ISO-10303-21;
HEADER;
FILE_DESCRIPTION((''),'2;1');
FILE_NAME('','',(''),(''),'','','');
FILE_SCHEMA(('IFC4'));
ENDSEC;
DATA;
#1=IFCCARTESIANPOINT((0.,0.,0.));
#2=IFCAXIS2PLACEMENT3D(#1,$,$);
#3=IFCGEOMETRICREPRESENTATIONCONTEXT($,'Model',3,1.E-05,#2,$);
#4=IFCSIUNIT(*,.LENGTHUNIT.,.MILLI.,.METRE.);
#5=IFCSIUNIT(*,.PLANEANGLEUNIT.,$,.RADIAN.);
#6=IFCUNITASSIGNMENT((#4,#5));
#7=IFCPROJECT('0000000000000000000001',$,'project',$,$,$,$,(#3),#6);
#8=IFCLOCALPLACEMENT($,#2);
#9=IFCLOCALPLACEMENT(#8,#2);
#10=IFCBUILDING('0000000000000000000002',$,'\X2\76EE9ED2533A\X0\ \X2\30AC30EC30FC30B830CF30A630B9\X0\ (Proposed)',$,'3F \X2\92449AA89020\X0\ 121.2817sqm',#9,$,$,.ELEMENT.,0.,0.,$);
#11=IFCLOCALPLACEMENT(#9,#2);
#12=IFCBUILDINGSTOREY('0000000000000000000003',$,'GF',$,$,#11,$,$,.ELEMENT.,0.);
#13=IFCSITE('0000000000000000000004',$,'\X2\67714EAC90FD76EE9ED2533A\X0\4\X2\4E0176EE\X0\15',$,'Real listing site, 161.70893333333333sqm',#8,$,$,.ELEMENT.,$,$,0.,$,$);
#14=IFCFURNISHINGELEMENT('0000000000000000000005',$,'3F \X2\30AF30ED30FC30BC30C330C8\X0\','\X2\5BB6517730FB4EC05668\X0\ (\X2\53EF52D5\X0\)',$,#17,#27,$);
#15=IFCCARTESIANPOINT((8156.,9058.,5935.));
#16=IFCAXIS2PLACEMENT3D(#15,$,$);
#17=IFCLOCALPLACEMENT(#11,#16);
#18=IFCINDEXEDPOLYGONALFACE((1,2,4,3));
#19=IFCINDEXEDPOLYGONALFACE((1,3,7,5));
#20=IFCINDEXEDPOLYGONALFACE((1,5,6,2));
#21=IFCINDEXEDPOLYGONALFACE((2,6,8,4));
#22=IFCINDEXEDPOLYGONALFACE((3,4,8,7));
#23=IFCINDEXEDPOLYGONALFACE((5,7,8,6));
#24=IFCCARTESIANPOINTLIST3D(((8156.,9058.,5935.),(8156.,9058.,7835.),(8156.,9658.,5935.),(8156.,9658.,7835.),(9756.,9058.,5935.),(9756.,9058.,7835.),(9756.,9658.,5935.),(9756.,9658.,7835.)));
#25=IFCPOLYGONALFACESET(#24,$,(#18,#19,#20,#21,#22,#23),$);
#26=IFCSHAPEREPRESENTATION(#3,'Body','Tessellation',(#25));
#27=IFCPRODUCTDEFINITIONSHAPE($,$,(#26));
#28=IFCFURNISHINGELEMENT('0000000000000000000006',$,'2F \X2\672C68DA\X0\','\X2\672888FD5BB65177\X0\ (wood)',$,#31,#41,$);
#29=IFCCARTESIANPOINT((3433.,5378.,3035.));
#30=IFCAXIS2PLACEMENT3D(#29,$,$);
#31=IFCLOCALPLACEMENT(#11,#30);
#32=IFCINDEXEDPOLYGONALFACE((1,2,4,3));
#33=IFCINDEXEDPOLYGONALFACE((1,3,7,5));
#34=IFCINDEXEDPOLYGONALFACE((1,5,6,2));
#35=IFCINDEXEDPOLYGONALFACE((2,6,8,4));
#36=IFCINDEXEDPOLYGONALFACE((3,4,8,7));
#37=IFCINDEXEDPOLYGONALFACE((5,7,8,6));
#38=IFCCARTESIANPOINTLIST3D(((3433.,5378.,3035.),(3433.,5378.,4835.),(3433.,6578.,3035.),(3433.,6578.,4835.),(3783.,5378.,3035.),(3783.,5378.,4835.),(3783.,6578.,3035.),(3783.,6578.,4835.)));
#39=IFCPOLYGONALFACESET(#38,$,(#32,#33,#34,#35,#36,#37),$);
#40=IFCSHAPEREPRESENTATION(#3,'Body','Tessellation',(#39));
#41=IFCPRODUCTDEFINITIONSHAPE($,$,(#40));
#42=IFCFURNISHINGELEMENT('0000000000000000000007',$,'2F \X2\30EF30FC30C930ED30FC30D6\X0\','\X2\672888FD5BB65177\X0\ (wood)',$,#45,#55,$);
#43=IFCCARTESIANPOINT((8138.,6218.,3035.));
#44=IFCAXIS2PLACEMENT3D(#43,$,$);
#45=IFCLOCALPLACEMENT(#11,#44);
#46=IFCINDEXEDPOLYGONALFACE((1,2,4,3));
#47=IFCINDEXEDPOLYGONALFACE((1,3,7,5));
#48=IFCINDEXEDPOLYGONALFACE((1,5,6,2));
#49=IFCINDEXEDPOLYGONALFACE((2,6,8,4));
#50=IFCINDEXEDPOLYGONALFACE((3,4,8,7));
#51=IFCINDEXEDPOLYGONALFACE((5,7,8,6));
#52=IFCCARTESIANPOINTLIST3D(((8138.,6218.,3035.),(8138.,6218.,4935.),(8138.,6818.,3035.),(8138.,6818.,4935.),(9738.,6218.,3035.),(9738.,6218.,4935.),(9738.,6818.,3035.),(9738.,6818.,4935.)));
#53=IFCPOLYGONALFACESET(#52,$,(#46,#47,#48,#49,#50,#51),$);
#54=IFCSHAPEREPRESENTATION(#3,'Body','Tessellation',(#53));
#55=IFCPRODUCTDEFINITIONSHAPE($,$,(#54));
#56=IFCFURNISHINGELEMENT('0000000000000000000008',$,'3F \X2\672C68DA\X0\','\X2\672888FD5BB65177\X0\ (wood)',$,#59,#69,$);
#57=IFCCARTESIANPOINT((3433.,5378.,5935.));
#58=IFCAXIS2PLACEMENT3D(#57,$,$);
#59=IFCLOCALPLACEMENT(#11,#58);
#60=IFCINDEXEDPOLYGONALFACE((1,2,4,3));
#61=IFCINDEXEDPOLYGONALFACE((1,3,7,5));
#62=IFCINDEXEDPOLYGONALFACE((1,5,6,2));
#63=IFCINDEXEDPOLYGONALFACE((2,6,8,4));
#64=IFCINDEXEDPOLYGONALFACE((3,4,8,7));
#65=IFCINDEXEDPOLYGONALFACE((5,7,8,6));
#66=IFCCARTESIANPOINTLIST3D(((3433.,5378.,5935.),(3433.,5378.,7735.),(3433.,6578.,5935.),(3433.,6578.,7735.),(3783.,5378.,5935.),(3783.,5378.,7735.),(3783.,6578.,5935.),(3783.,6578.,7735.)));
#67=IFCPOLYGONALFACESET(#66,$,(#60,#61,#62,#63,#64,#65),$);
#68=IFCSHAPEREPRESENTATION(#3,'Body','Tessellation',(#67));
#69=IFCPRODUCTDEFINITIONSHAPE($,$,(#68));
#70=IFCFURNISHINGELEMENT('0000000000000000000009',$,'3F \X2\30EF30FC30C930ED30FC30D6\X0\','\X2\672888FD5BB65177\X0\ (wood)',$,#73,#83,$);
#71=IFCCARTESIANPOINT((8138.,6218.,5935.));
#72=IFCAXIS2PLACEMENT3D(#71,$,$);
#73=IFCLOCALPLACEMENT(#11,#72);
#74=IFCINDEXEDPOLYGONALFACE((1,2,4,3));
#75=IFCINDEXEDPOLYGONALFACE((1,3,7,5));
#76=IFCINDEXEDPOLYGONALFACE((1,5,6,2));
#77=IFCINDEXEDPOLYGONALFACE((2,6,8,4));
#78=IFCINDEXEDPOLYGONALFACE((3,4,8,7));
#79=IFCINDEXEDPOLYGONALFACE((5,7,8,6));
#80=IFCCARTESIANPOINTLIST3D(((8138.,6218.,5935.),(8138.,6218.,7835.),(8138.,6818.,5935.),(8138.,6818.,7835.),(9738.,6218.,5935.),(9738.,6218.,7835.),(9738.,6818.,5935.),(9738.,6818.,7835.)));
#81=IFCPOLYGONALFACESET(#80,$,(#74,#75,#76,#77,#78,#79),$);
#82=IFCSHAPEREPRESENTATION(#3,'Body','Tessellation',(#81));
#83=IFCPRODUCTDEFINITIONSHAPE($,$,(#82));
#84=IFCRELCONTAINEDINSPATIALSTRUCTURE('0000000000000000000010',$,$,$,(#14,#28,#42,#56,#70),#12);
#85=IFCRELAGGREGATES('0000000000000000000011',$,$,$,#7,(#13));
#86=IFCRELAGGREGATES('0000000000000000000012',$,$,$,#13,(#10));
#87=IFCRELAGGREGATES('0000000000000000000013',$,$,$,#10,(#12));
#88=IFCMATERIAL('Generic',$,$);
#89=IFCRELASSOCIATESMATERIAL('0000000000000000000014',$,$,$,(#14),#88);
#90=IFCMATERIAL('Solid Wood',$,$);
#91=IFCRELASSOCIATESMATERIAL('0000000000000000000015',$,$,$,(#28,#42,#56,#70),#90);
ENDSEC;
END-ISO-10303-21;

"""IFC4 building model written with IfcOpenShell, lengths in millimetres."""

from ifc_helpers import new_model, si_unit, frame, frame_2d, origin, place, context, project, spatial, rectangle, extrude, material, element, save


model = new_model("IFC4")

# Units and contexts
model_context = context("Model", 3, precision=1e-05, world=origin())
ifc_project = project(units=[si_unit("LENGTHUNIT", "METRE", prefix="MILLI"), si_unit("PLANEANGLEUNIT", "RADIAN")], contexts=[model_context])

# Site, building, storey
site_placement = place(None, origin())
site = spatial("IfcSite", under=ifc_project, at=site_placement, Name="東京都目黒区4丁目15", ObjectType="Real listing site, 161.70893333333333sqm", CompositionType="ELEMENT", RefElevation=0.0)
building_placement = place(site_placement, origin())
building = spatial("IfcBuilding", under=site, at=building_placement, Name="目黒区 ガレージハウス (Proposed)", ObjectType="3F 鉄骨造 121.2817sqm", CompositionType="ELEMENT", ElevationOfRefHeight=0.0, ElevationOfTerrain=0.0)
storey_placement = place(building_placement, origin())
storey = spatial("IfcBuildingStorey", under=building, at=storey_placement, Name="GF", CompositionType="ELEMENT", Elevation=0.0)

# Shared definitions
ifc_material_1 = material(Name="Solid Wood")

# Furnishing elements
ifc_material_2 = material(Name="Generic")
furnishing_1_placement = place(storey_placement, frame((8156.0, 9058.0, 5935.0)))
element("IfcFurnishingElement", 1, at=furnishing_1_placement, inside=storey, material=ifc_material_2, Name="3F クローゼット", Description="家具・什器 (可動)", context=model_context, shape_type="SweptSolid", body=[
    extrude(rectangle(XDim=1600.0, YDim=600.0, at=frame_2d((800.0, 300.0))), frame((8156.0, 9058.0, 5935.0)), (0.0, 0.0, 1.0), 1900.0),
])
furnishing_2_placement = place(storey_placement, frame((3433.0, 5378.0, 3035.0)))
element("IfcFurnishingElement", 2, at=furnishing_2_placement, inside=storey, material=ifc_material_1, Name="2F 本棚", Description="木製家具 (wood)", context=model_context, shape_type="SweptSolid", body=[
    extrude(rectangle(XDim=350.0, YDim=1200.0, at=frame_2d((175.0, 600.0))), frame((3433.0, 5378.0, 3035.0)), (0.0, 0.0, 1.0), 1800.0),
])
furnishing_3_placement = place(storey_placement, frame((8138.0, 6218.0, 3035.0)))
element("IfcFurnishingElement", 3, at=furnishing_3_placement, inside=storey, material=ifc_material_1, Name="2F ワードローブ", Description="木製家具 (wood)", context=model_context, shape_type="SweptSolid", body=[
    extrude(rectangle(XDim=1600.0, YDim=600.0, at=frame_2d((800.0, 300.0))), frame((8138.0, 6218.0, 3035.0)), (0.0, 0.0, 1.0), 1900.0),
])
furnishing_4_placement = place(storey_placement, frame((3433.0, 5378.0, 5935.0)))
element("IfcFurnishingElement", 4, at=furnishing_4_placement, inside=storey, material=ifc_material_1, Name="3F 本棚", Description="木製家具 (wood)", context=model_context, shape_type="SweptSolid", body=[
    extrude(rectangle(XDim=350.0, YDim=1200.0, at=frame_2d((175.0, 600.0))), frame((3433.0, 5378.0, 5935.0)), (0.0, 0.0, 1.0), 1800.0),
])
furnishing_5_placement = place(storey_placement, frame((8138.0, 6218.0, 5935.0)))
element("IfcFurnishingElement", 5, at=furnishing_5_placement, inside=storey, material=ifc_material_1, Name="3F ワードローブ", Description="木製家具 (wood)", context=model_context, shape_type="SweptSolid", body=[
    extrude(rectangle(XDim=1600.0, YDim=600.0, at=frame_2d((800.0, 300.0))), frame((8138.0, 6218.0, 5935.0)), (0.0, 0.0, 1.0), 1900.0),
])

save(model, "model.ifc")
